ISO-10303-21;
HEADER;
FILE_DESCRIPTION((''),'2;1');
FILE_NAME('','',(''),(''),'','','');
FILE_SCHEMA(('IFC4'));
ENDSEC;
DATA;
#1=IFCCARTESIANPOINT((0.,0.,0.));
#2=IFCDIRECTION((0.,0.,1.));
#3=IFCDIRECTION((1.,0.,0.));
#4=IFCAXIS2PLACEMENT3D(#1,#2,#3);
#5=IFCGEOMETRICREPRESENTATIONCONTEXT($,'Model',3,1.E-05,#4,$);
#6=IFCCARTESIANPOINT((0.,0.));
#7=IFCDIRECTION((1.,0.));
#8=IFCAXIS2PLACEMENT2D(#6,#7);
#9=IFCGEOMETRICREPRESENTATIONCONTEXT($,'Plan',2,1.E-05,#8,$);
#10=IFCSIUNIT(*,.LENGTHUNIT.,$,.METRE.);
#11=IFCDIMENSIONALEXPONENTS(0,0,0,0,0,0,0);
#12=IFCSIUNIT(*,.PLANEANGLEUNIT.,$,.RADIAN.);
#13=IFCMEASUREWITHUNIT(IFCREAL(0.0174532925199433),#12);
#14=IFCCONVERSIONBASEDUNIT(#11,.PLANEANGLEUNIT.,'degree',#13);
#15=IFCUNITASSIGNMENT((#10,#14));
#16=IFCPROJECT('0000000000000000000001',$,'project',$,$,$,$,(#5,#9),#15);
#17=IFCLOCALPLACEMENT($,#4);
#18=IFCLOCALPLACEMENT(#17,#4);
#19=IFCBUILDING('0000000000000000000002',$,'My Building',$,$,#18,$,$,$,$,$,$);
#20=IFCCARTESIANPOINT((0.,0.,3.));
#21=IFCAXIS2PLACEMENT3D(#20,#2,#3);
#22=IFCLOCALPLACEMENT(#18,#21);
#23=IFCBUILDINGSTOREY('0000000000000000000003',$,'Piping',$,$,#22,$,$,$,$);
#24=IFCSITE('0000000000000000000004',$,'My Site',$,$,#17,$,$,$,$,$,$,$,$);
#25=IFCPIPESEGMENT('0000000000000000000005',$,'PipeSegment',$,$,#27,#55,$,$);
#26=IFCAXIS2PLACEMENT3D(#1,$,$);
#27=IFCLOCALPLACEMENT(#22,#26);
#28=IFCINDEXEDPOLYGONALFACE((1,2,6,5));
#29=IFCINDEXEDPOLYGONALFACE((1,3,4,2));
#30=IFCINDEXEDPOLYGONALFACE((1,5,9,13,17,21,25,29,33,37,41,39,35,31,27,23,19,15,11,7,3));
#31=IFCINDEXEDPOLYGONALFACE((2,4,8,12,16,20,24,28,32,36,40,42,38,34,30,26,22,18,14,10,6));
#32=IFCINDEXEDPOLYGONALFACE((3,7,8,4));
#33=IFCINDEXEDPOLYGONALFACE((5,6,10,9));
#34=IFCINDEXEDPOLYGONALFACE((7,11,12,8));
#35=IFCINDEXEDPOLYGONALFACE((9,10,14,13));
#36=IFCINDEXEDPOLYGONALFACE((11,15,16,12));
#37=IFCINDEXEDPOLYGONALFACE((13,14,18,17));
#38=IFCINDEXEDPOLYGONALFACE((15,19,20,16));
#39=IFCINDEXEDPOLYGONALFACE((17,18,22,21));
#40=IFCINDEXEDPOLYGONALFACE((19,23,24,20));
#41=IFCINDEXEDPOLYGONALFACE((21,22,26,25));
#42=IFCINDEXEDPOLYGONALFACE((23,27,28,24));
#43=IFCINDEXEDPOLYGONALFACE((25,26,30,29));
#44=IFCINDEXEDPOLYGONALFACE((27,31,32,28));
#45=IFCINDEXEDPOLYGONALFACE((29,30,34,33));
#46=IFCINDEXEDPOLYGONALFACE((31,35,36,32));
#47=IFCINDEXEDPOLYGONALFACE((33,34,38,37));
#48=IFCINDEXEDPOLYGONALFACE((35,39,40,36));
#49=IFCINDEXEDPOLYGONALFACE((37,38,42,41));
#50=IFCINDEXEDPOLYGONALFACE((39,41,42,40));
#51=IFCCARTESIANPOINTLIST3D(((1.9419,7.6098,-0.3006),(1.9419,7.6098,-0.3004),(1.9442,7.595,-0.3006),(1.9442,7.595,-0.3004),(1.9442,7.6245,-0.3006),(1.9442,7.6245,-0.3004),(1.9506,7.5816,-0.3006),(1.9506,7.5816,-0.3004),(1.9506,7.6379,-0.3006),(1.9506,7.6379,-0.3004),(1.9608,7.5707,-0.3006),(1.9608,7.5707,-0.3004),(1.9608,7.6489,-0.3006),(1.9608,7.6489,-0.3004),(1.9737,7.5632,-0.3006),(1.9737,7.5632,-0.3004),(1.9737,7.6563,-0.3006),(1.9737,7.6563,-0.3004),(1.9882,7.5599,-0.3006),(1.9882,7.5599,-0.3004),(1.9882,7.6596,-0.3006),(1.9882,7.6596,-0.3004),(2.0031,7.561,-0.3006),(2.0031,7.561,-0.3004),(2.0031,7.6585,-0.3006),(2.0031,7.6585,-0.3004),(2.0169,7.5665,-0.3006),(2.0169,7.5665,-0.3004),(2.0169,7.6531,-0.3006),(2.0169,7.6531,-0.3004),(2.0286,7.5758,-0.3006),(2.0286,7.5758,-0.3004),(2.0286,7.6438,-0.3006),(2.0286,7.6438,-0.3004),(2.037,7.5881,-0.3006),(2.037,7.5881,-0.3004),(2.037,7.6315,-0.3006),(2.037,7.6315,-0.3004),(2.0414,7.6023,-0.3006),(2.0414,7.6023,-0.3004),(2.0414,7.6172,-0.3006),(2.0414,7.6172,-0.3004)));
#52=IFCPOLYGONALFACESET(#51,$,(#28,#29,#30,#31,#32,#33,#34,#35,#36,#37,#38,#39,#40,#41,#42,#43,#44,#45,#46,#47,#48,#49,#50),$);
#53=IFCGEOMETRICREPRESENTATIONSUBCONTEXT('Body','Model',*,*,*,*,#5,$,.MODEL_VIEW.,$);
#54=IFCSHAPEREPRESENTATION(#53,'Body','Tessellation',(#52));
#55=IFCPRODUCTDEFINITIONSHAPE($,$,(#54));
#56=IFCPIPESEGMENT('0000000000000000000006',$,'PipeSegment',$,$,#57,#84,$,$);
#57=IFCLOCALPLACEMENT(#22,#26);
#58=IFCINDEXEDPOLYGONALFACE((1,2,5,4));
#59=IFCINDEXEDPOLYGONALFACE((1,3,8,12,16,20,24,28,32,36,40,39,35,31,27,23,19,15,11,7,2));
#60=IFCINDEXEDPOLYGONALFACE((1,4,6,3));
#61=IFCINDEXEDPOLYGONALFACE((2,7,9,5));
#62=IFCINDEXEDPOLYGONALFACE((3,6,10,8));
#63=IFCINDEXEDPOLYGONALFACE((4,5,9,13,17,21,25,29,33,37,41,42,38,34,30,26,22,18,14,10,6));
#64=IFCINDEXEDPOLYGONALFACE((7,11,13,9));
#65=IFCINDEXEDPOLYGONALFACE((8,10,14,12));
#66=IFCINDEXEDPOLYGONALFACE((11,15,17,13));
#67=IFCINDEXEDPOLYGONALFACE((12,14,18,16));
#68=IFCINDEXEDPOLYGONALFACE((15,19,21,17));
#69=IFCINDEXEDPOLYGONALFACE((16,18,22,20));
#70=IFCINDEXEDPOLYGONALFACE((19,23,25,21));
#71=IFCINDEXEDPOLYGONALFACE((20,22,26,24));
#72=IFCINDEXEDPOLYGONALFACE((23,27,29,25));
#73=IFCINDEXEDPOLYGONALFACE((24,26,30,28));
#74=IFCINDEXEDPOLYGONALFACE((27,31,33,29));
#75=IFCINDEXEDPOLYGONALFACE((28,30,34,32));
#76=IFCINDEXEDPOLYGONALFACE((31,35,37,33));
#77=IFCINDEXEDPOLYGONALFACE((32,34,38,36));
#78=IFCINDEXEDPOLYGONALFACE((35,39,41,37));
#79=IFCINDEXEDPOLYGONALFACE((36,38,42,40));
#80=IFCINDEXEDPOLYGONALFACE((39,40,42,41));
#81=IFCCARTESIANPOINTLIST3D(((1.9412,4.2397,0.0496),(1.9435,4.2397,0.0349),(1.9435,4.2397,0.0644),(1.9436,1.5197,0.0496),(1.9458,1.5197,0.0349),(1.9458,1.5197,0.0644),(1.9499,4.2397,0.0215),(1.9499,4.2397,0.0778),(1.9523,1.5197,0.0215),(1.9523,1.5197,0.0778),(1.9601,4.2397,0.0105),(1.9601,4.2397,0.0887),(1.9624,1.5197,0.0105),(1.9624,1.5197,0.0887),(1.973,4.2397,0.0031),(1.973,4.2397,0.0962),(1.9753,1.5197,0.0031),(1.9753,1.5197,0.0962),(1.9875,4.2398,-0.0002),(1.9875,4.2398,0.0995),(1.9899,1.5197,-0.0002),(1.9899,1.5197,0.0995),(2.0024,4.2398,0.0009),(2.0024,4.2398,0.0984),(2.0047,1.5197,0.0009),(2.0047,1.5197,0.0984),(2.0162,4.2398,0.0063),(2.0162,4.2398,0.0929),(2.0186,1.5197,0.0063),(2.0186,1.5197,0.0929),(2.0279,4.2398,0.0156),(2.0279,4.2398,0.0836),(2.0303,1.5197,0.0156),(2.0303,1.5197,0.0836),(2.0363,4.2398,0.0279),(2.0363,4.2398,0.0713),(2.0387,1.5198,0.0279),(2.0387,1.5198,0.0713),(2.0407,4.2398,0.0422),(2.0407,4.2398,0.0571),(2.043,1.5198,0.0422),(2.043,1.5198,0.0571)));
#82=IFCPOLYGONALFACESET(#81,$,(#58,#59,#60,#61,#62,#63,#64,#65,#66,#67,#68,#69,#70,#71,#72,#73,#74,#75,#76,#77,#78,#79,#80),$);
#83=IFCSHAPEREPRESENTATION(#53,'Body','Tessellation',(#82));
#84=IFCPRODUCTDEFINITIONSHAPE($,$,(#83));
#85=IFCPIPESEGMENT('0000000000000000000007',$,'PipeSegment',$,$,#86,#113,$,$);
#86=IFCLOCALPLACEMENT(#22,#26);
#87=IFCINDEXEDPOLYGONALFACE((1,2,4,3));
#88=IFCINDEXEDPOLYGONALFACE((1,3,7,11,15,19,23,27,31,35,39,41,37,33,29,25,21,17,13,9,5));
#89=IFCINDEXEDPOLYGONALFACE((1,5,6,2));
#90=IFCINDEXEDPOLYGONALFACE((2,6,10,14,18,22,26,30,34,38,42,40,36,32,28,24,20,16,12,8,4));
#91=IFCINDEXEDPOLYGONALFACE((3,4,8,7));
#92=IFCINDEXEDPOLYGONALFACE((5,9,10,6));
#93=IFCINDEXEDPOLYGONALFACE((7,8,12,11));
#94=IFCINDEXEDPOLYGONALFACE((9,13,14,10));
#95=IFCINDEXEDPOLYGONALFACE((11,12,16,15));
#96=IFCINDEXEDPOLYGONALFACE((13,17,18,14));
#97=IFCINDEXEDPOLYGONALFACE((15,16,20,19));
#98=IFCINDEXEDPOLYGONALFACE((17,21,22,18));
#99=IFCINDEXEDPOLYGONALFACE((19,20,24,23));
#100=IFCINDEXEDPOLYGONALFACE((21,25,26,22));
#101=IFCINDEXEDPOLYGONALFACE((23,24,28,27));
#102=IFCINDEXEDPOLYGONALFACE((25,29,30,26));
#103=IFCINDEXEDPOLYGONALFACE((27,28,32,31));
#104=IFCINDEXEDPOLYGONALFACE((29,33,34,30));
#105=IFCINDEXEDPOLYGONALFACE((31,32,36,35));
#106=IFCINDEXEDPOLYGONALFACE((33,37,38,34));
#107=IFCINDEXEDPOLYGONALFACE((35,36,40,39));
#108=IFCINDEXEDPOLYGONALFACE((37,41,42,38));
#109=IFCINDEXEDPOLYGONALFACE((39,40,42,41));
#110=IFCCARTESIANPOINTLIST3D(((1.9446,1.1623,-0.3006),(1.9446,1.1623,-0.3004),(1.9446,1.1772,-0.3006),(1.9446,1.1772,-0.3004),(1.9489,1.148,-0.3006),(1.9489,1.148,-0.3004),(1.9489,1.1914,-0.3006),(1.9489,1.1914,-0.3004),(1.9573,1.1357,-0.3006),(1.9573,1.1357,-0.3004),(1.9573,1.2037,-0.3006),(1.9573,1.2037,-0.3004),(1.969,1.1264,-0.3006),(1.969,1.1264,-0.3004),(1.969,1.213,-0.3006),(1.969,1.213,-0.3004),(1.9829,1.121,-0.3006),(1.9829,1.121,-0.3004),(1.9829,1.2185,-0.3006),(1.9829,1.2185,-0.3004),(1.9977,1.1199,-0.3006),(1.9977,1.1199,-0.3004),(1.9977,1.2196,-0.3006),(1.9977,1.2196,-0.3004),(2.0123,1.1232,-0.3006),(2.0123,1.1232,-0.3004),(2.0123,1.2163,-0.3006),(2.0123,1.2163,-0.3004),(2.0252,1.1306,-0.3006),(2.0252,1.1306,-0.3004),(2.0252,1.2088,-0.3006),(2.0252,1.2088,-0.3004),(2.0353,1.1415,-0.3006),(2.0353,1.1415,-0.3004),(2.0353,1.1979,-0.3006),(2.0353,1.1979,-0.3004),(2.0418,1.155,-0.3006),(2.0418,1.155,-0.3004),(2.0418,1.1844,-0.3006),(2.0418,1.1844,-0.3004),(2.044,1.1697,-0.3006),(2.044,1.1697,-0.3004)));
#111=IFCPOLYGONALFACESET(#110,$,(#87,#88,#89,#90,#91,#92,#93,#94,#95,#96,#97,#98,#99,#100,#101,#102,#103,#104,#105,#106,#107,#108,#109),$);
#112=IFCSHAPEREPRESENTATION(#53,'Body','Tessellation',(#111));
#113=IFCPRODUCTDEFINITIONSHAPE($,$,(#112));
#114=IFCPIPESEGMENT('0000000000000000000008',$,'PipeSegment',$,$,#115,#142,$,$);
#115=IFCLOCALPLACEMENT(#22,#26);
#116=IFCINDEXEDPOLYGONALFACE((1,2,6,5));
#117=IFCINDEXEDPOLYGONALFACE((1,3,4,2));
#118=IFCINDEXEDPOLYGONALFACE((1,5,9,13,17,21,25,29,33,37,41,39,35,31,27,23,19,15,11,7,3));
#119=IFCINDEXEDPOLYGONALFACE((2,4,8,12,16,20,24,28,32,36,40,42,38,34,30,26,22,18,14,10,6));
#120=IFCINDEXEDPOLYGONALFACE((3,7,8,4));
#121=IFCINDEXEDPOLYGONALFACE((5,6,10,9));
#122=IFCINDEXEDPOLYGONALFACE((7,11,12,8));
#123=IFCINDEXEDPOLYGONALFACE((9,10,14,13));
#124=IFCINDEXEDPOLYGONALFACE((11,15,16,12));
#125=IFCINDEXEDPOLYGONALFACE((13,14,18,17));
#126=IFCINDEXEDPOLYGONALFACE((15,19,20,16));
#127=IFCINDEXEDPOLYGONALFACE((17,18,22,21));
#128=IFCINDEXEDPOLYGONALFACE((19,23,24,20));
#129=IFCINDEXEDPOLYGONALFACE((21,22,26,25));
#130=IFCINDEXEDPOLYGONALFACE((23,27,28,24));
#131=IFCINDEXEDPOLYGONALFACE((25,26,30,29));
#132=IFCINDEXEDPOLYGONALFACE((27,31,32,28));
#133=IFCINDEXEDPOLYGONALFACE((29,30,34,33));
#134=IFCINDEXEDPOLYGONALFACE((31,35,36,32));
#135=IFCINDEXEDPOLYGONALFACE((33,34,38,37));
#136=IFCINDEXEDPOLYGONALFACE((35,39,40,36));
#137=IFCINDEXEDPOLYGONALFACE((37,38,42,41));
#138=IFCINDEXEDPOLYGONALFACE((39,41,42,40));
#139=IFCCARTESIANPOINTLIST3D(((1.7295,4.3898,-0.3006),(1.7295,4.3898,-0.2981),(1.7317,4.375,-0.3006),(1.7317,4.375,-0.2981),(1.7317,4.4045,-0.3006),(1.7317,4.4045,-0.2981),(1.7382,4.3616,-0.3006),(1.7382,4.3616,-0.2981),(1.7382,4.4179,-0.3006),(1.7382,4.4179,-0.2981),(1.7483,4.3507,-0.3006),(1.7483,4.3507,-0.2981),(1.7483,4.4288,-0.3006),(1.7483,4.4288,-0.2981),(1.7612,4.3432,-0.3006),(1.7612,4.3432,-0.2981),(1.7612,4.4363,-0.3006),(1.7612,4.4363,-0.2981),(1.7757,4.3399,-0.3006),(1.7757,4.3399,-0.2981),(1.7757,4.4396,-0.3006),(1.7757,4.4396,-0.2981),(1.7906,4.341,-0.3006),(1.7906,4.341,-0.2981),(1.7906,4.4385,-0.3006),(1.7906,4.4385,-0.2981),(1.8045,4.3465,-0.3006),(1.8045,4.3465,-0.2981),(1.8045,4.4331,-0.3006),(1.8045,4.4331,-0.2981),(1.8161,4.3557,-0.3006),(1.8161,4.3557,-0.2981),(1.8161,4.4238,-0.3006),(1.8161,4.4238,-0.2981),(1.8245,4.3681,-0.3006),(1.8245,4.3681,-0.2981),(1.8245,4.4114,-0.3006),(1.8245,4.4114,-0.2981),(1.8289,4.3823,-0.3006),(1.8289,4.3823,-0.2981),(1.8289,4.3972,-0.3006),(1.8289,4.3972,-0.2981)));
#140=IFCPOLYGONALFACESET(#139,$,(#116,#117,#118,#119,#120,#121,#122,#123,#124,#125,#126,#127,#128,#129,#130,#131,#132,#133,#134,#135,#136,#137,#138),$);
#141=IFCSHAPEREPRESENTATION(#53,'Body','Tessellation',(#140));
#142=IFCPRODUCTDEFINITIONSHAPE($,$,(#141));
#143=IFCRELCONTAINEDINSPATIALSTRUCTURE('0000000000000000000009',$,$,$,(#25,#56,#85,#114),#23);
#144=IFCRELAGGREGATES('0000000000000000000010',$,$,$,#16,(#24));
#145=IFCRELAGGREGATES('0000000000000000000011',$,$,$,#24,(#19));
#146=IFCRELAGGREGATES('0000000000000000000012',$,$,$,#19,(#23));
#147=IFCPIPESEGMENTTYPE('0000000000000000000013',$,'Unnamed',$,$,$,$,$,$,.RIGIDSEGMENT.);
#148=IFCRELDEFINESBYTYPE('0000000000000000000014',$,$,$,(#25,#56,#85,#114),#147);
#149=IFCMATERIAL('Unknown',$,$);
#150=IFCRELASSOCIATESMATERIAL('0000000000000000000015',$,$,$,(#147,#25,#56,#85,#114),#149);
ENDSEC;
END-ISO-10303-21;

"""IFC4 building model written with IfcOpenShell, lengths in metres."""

from ifc_helpers import new_model, entity, si_unit, converted_unit, frame, origin_with_axes, origin_2d_with_axis, place, context, subcontext, project, spatial, circle, extrude, material, material_profile, profile_set, profile_usage, type_object, element, save


model = new_model("IFC4")

# Units and contexts
model_context = context("Model", 3, precision=1e-05, world=origin_with_axes())
plan_context = context("Plan", 2, precision=1e-05, world=origin_2d_with_axis())
body_context = subcontext(model_context, "Body", "Model", "MODEL_VIEW")
ifc_project = project(units=[si_unit("LENGTHUNIT", "METRE"), converted_unit("PLANEANGLEUNIT", "degree", entity("IfcReal", 0.0174532925199433), si_unit("PLANEANGLEUNIT", "RADIAN"), dimensions=[0, 0, 0, 0, 0, 0, 0])], contexts=[model_context, plan_context])

# Site, building, storey
site_placement = place(None, origin_with_axes())
site = spatial("IfcSite", under=ifc_project, at=site_placement, Name="My Site")
building_placement = place(site_placement, origin_with_axes())
building = spatial("IfcBuilding", under=site, at=building_placement, Name="My Building")
storey_placement = place(building_placement, frame((0.0, 0.0, 3.0), z_axis=(0.0, 0.0, 1.0), x_axis=(1.0, 0.0, 0.0)))
storey = spatial("IfcBuildingStorey", under=building, at=storey_placement, Name="Piping")

# Pipe segments
ifc_material = material(Name="Unknown")
ifc_material_profile_1 = material_profile(ifc_material, circle(Radius=0.05))
ifc_profile_set_1 = profile_set([ifc_material_profile_1])
pipe_segment_type = type_object("IfcPipeSegmentType", Name="Unnamed", PredefinedType="RIGIDSEGMENT", material=ifc_profile_set_1)
ifc_profile_usage_1 = profile_usage(ifc_profile_set_1, cardinal=16)
pipe_segment_1_placement = place(storey_placement, frame((1.9919, 7.6098, -0.3004), z_axis=(0.0, 0.0, -1.0), x_axis=(-1.0, 0.0, 0.0)))
element("IfcPipeSegment", 1, at=pipe_segment_1_placement, inside=storey, type_object=pipe_segment_type, material=ifc_profile_usage_1, Name="PipeSegment", context=body_context, shape_type="SweptSolid", body=[
    extrude(circle(Radius=0.05), origin_with_axes(), (0.0, 0.0, 1.0), 0.0002),
])
ifc_profile_usage_2 = profile_usage(ifc_profile_set_1, cardinal=5)
pipe_segment_2_placement = place(storey_placement, frame((1.9936, 1.5197, 0.0496), z_axis=(-0.000873, 1.0, 0.000001), x_axis=(-1.0, -0.000873, 0.0)))
element("IfcPipeSegment", 2, at=pipe_segment_2_placement, inside=storey, type_object=pipe_segment_type, material=ifc_profile_usage_2, Name="PipeSegment", context=body_context, shape_type="SweptSolid", body=[
    extrude(circle(Radius=0.05), origin_with_axes(), (0.0, 0.0, 1.0), 2.7201),
])
ifc_profile_usage_3 = profile_usage(ifc_profile_set_1, cardinal=16)
pipe_segment_3_placement = place(storey_placement, frame((1.994, 1.1697, -0.3004), z_axis=(0.0, 0.0, -1.0), x_axis=(1.0, 0.0, 0.0)))
element("IfcPipeSegment", 3, at=pipe_segment_3_placement, inside=storey, type_object=pipe_segment_type, material=ifc_profile_usage_3, Name="PipeSegment", context=body_context, shape_type="SweptSolid", body=[
    extrude(circle(Radius=0.05), origin_with_axes(), (0.0, 0.0, 1.0), 0.0002),
])
ifc_profile_usage_4 = profile_usage(ifc_profile_set_1, cardinal=5)
pipe_segment_4_placement = place(storey_placement, frame((1.7795, 4.3898, -0.2981), z_axis=(0.0, 0.0, -1.0), x_axis=(-1.0, 0.0, 0.0)))
element("IfcPipeSegment", 4, at=pipe_segment_4_placement, inside=storey, type_object=pipe_segment_type, material=ifc_profile_usage_4, Name="PipeSegment", context=body_context, shape_type="SweptSolid", body=[
    extrude(circle(Radius=0.05), origin_with_axes(), (0.0, 0.0, 1.0), 0.0025),
])

save(model, "model.ifc")
